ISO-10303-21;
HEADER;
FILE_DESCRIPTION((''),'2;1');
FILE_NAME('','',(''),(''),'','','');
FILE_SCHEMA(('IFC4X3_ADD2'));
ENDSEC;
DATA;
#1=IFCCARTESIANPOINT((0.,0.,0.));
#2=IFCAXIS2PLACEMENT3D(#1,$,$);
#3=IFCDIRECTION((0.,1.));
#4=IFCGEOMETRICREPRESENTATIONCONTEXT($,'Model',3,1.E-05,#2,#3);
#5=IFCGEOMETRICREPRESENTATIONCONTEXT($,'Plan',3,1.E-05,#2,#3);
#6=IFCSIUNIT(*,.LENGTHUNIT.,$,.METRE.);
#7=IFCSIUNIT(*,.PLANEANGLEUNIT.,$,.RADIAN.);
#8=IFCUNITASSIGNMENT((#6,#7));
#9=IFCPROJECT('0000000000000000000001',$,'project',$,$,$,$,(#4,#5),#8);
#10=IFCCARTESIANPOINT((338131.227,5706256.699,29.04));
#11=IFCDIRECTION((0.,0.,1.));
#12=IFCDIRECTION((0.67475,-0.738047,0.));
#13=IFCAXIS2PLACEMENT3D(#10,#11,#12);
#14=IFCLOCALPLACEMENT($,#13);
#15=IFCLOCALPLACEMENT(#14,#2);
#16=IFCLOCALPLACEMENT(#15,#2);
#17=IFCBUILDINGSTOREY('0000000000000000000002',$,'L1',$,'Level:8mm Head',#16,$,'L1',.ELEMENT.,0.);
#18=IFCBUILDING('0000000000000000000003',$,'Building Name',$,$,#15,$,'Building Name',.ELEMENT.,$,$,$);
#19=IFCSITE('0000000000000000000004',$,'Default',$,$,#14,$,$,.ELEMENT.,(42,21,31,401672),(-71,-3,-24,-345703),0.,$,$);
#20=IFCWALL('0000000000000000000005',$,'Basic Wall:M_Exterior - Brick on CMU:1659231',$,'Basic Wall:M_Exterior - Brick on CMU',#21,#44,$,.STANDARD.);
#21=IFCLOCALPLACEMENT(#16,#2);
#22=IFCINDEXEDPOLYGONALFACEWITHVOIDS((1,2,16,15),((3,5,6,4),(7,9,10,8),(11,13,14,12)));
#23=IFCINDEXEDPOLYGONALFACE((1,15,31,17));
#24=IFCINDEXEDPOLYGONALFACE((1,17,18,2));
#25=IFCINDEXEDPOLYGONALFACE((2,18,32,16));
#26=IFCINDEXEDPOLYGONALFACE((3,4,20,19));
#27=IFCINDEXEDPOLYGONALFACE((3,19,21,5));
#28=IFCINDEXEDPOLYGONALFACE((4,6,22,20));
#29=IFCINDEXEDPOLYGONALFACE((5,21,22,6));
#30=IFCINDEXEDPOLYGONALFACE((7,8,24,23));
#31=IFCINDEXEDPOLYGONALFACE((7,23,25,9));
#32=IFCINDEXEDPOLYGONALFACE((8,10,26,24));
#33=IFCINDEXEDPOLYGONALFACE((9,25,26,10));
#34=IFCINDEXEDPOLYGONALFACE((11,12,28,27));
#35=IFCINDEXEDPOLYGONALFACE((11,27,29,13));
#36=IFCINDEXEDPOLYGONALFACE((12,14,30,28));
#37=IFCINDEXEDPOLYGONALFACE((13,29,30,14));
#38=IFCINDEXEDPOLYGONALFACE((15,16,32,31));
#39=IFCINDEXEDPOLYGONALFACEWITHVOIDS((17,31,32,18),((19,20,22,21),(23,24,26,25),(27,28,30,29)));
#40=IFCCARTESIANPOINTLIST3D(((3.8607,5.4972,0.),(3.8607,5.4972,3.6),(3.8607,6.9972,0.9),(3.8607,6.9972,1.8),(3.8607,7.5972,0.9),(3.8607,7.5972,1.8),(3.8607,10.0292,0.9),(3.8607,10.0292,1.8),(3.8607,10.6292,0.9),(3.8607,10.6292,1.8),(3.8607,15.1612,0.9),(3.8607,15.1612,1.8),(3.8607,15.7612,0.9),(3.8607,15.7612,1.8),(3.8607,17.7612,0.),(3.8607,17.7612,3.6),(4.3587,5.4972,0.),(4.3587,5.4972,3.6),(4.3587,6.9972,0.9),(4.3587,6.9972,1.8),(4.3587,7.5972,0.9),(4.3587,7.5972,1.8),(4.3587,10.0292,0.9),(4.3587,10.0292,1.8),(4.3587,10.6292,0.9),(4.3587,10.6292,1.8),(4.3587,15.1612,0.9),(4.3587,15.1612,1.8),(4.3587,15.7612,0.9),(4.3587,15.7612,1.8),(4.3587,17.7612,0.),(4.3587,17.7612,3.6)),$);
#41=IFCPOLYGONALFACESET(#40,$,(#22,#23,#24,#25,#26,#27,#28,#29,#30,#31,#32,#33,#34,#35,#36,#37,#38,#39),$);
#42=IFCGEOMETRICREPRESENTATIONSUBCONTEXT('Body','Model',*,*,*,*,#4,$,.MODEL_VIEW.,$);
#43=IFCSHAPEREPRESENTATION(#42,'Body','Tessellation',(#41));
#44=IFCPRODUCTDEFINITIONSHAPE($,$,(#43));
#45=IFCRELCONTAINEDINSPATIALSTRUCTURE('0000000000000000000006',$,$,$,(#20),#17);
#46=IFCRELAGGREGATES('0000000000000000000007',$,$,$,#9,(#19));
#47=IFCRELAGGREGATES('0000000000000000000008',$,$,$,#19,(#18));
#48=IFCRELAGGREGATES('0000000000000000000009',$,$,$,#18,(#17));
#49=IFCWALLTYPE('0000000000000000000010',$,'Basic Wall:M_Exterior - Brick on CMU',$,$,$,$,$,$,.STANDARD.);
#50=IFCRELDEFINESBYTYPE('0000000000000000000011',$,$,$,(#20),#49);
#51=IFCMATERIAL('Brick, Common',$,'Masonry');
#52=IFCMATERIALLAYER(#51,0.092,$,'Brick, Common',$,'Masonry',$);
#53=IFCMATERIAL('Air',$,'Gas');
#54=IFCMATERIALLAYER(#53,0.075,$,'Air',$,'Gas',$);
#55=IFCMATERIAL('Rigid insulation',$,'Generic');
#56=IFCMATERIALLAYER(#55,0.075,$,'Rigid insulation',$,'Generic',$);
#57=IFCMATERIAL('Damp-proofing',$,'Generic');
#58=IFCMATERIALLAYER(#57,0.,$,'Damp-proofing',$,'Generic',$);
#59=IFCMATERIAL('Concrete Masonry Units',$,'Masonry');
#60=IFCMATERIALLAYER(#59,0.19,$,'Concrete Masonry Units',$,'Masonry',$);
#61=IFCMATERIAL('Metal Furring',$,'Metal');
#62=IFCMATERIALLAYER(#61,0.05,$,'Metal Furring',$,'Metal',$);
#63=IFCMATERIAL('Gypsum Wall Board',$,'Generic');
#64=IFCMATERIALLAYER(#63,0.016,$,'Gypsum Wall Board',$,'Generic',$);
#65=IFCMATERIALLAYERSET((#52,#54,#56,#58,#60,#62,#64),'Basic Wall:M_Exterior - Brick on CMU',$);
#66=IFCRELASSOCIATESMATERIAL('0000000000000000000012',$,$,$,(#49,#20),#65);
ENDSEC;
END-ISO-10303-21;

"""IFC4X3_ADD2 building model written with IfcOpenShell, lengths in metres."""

from ifc_helpers import new_model, si_unit, direction, frame, frame_2d, origin, origin_2d_with_axis, place, context, subcontext, project, spatial, rectangle, extrude, material, layer, layer_set, type_object, element, save


model = new_model("IFC4X3_ADD2")

# Units and contexts
model_context = context("Model", 3, precision=1e-05, world=origin(), true_north=direction((0.0, 1.0)))
plan_context = context("Plan", 3, precision=1e-05, world=origin(), true_north=direction((0.0, 1.0)))
body_context = subcontext(model_context, "Body", "Model", "MODEL_VIEW")
ifc_project = project(units=[si_unit("LENGTHUNIT", "METRE"), si_unit("PLANEANGLEUNIT", "RADIAN")], contexts=[model_context, plan_context])

# Site, building, storey
site_placement = place(None, frame((338131.227, 5706256.699, 29.04), z_axis=(0.0, 0.0, 1.0), x_axis=(0.67475, -0.738047, 0.0)))
site = spatial("IfcSite", under=ifc_project, at=site_placement, Name="Default", CompositionType="ELEMENT", RefLatitude=(42, 21, 31, 401672), RefLongitude=(-71, -3, -24, -345703), RefElevation=0.0)
building_placement = place(site_placement, origin())
building = spatial("IfcBuilding", under=site, at=building_placement, Name="Building Name", LongName="Building Name", CompositionType="ELEMENT")
storey_placement = place(building_placement, origin())
storey = spatial("IfcBuildingStorey", under=building, at=storey_placement, Name="L1", ObjectType="Level:8mm Head", LongName="L1", CompositionType="ELEMENT", Elevation=0.0)

# Shared definitions
ifc_material_1 = material(Name="Brick, Common", Category="Masonry")
ifc_layer_1 = layer(ifc_material_1, 0.092, Name="Brick, Common", Category="Masonry")
ifc_material_2 = material(Name="Air", Category="Gas")
ifc_layer_2 = layer(ifc_material_2, 0.075, Name="Air", Category="Gas")
ifc_material_3 = material(Name="Rigid insulation", Category="Generic")
ifc_layer_3 = layer(ifc_material_3, 0.075, Name="Rigid insulation", Category="Generic")
ifc_material_4 = material(Name="Damp-proofing", Category="Generic")
ifc_layer_4 = layer(ifc_material_4, 0.0, Name="Damp-proofing", Category="Generic")
ifc_material_5 = material(Name="Concrete Masonry Units", Category="Masonry")
ifc_layer_5 = layer(ifc_material_5, 0.19, Name="Concrete Masonry Units", Category="Masonry")
ifc_material_6 = material(Name="Metal Furring", Category="Metal")
ifc_layer_6 = layer(ifc_material_6, 0.05, Name="Metal Furring", Category="Metal")
ifc_material_7 = material(Name="Gypsum Wall Board", Category="Generic")
ifc_layer_7 = layer(ifc_material_7, 0.016, Name="Gypsum Wall Board", Category="Generic")
ifc_layer_set_1 = layer_set([ifc_layer_1, ifc_layer_2, ifc_layer_3, ifc_layer_4, ifc_layer_5, ifc_layer_6, ifc_layer_7], Name="Basic Wall:M_Exterior - Brick on CMU")
wall_type = type_object("IfcWallType", Name="Basic Wall:M_Exterior - Brick on CMU", PredefinedType="STANDARD", material=ifc_layer_set_1)

# Wall, openings
wall_1_placement = place(storey_placement, frame((4.1097, 5.4972, 0.0), z_axis=(0.0, 0.0, 1.0), x_axis=(0.0, 1.0, 0.0)))
wall_1 = element("IfcWall", 1, at=wall_1_placement, inside=storey, type_object=wall_type, material=ifc_layer_set_1, Name="Basic Wall:M_Exterior - Brick on CMU:1659231", ObjectType="Basic Wall:M_Exterior - Brick on CMU", PredefinedType="STANDARD", context=body_context, shape_type="SweptSolid", body=[
    extrude(rectangle(XDim=12.264, YDim=0.498, at=frame_2d((6.132, 0.0), x_axis=(-1.0, 0.0))), origin(), (0.0, 0.0, 1.0), 3.6),
])
opening_1_placement = place(wall_1_placement, frame((-5.4972, 4.1097, 0.9)))
element("IfcOpeningElement", 2, at=opening_1_placement, cuts=wall_1, PredefinedType="OPENING", context=body_context, shape_type="SweptSolid", body=[
    extrude(rectangle(XDim=0.9, YDim=0.6, at=frame_2d((0.0, 0.0), x_axis=(1.0, 0.0))), frame((15.4612, -5.8827, 0.45), z_axis=(0.0, 1.0, 0.0), x_axis=(0.0, 0.0, -1.0)), (0.0, 0.0, 1.0), 3.048),
])
opening_2_placement = place(wall_1_placement, frame((-5.4972, 4.1097, 0.9)))
element("IfcOpeningElement", 3, at=opening_2_placement, cuts=wall_1, PredefinedType="OPENING", context=body_context, shape_type="SweptSolid", body=[
    extrude(rectangle(XDim=0.9, YDim=0.6, at=frame_2d((0.0, 0.0), x_axis=(1.0, 0.0))), frame((10.3292, -5.8827, 0.45), z_axis=(0.0, 1.0, 0.0), x_axis=(0.0, 0.0, -1.0)), (0.0, 0.0, 1.0), 3.048),
])
opening_3_placement = place(wall_1_placement, frame((-5.4972, 4.1097, 0.9)))
element("IfcOpeningElement", 4, at=opening_3_placement, cuts=wall_1, PredefinedType="OPENING", context=body_context, shape_type="SweptSolid", body=[
    extrude(rectangle(XDim=0.9, YDim=0.6, at=origin_2d_with_axis()), frame((7.2972, -5.8827, 0.45), z_axis=(0.0, 1.0, 0.0), x_axis=(0.0, 0.0, -1.0)), (0.0, 0.0, 1.0), 3.048),
])

save(model, "model.ifc")
